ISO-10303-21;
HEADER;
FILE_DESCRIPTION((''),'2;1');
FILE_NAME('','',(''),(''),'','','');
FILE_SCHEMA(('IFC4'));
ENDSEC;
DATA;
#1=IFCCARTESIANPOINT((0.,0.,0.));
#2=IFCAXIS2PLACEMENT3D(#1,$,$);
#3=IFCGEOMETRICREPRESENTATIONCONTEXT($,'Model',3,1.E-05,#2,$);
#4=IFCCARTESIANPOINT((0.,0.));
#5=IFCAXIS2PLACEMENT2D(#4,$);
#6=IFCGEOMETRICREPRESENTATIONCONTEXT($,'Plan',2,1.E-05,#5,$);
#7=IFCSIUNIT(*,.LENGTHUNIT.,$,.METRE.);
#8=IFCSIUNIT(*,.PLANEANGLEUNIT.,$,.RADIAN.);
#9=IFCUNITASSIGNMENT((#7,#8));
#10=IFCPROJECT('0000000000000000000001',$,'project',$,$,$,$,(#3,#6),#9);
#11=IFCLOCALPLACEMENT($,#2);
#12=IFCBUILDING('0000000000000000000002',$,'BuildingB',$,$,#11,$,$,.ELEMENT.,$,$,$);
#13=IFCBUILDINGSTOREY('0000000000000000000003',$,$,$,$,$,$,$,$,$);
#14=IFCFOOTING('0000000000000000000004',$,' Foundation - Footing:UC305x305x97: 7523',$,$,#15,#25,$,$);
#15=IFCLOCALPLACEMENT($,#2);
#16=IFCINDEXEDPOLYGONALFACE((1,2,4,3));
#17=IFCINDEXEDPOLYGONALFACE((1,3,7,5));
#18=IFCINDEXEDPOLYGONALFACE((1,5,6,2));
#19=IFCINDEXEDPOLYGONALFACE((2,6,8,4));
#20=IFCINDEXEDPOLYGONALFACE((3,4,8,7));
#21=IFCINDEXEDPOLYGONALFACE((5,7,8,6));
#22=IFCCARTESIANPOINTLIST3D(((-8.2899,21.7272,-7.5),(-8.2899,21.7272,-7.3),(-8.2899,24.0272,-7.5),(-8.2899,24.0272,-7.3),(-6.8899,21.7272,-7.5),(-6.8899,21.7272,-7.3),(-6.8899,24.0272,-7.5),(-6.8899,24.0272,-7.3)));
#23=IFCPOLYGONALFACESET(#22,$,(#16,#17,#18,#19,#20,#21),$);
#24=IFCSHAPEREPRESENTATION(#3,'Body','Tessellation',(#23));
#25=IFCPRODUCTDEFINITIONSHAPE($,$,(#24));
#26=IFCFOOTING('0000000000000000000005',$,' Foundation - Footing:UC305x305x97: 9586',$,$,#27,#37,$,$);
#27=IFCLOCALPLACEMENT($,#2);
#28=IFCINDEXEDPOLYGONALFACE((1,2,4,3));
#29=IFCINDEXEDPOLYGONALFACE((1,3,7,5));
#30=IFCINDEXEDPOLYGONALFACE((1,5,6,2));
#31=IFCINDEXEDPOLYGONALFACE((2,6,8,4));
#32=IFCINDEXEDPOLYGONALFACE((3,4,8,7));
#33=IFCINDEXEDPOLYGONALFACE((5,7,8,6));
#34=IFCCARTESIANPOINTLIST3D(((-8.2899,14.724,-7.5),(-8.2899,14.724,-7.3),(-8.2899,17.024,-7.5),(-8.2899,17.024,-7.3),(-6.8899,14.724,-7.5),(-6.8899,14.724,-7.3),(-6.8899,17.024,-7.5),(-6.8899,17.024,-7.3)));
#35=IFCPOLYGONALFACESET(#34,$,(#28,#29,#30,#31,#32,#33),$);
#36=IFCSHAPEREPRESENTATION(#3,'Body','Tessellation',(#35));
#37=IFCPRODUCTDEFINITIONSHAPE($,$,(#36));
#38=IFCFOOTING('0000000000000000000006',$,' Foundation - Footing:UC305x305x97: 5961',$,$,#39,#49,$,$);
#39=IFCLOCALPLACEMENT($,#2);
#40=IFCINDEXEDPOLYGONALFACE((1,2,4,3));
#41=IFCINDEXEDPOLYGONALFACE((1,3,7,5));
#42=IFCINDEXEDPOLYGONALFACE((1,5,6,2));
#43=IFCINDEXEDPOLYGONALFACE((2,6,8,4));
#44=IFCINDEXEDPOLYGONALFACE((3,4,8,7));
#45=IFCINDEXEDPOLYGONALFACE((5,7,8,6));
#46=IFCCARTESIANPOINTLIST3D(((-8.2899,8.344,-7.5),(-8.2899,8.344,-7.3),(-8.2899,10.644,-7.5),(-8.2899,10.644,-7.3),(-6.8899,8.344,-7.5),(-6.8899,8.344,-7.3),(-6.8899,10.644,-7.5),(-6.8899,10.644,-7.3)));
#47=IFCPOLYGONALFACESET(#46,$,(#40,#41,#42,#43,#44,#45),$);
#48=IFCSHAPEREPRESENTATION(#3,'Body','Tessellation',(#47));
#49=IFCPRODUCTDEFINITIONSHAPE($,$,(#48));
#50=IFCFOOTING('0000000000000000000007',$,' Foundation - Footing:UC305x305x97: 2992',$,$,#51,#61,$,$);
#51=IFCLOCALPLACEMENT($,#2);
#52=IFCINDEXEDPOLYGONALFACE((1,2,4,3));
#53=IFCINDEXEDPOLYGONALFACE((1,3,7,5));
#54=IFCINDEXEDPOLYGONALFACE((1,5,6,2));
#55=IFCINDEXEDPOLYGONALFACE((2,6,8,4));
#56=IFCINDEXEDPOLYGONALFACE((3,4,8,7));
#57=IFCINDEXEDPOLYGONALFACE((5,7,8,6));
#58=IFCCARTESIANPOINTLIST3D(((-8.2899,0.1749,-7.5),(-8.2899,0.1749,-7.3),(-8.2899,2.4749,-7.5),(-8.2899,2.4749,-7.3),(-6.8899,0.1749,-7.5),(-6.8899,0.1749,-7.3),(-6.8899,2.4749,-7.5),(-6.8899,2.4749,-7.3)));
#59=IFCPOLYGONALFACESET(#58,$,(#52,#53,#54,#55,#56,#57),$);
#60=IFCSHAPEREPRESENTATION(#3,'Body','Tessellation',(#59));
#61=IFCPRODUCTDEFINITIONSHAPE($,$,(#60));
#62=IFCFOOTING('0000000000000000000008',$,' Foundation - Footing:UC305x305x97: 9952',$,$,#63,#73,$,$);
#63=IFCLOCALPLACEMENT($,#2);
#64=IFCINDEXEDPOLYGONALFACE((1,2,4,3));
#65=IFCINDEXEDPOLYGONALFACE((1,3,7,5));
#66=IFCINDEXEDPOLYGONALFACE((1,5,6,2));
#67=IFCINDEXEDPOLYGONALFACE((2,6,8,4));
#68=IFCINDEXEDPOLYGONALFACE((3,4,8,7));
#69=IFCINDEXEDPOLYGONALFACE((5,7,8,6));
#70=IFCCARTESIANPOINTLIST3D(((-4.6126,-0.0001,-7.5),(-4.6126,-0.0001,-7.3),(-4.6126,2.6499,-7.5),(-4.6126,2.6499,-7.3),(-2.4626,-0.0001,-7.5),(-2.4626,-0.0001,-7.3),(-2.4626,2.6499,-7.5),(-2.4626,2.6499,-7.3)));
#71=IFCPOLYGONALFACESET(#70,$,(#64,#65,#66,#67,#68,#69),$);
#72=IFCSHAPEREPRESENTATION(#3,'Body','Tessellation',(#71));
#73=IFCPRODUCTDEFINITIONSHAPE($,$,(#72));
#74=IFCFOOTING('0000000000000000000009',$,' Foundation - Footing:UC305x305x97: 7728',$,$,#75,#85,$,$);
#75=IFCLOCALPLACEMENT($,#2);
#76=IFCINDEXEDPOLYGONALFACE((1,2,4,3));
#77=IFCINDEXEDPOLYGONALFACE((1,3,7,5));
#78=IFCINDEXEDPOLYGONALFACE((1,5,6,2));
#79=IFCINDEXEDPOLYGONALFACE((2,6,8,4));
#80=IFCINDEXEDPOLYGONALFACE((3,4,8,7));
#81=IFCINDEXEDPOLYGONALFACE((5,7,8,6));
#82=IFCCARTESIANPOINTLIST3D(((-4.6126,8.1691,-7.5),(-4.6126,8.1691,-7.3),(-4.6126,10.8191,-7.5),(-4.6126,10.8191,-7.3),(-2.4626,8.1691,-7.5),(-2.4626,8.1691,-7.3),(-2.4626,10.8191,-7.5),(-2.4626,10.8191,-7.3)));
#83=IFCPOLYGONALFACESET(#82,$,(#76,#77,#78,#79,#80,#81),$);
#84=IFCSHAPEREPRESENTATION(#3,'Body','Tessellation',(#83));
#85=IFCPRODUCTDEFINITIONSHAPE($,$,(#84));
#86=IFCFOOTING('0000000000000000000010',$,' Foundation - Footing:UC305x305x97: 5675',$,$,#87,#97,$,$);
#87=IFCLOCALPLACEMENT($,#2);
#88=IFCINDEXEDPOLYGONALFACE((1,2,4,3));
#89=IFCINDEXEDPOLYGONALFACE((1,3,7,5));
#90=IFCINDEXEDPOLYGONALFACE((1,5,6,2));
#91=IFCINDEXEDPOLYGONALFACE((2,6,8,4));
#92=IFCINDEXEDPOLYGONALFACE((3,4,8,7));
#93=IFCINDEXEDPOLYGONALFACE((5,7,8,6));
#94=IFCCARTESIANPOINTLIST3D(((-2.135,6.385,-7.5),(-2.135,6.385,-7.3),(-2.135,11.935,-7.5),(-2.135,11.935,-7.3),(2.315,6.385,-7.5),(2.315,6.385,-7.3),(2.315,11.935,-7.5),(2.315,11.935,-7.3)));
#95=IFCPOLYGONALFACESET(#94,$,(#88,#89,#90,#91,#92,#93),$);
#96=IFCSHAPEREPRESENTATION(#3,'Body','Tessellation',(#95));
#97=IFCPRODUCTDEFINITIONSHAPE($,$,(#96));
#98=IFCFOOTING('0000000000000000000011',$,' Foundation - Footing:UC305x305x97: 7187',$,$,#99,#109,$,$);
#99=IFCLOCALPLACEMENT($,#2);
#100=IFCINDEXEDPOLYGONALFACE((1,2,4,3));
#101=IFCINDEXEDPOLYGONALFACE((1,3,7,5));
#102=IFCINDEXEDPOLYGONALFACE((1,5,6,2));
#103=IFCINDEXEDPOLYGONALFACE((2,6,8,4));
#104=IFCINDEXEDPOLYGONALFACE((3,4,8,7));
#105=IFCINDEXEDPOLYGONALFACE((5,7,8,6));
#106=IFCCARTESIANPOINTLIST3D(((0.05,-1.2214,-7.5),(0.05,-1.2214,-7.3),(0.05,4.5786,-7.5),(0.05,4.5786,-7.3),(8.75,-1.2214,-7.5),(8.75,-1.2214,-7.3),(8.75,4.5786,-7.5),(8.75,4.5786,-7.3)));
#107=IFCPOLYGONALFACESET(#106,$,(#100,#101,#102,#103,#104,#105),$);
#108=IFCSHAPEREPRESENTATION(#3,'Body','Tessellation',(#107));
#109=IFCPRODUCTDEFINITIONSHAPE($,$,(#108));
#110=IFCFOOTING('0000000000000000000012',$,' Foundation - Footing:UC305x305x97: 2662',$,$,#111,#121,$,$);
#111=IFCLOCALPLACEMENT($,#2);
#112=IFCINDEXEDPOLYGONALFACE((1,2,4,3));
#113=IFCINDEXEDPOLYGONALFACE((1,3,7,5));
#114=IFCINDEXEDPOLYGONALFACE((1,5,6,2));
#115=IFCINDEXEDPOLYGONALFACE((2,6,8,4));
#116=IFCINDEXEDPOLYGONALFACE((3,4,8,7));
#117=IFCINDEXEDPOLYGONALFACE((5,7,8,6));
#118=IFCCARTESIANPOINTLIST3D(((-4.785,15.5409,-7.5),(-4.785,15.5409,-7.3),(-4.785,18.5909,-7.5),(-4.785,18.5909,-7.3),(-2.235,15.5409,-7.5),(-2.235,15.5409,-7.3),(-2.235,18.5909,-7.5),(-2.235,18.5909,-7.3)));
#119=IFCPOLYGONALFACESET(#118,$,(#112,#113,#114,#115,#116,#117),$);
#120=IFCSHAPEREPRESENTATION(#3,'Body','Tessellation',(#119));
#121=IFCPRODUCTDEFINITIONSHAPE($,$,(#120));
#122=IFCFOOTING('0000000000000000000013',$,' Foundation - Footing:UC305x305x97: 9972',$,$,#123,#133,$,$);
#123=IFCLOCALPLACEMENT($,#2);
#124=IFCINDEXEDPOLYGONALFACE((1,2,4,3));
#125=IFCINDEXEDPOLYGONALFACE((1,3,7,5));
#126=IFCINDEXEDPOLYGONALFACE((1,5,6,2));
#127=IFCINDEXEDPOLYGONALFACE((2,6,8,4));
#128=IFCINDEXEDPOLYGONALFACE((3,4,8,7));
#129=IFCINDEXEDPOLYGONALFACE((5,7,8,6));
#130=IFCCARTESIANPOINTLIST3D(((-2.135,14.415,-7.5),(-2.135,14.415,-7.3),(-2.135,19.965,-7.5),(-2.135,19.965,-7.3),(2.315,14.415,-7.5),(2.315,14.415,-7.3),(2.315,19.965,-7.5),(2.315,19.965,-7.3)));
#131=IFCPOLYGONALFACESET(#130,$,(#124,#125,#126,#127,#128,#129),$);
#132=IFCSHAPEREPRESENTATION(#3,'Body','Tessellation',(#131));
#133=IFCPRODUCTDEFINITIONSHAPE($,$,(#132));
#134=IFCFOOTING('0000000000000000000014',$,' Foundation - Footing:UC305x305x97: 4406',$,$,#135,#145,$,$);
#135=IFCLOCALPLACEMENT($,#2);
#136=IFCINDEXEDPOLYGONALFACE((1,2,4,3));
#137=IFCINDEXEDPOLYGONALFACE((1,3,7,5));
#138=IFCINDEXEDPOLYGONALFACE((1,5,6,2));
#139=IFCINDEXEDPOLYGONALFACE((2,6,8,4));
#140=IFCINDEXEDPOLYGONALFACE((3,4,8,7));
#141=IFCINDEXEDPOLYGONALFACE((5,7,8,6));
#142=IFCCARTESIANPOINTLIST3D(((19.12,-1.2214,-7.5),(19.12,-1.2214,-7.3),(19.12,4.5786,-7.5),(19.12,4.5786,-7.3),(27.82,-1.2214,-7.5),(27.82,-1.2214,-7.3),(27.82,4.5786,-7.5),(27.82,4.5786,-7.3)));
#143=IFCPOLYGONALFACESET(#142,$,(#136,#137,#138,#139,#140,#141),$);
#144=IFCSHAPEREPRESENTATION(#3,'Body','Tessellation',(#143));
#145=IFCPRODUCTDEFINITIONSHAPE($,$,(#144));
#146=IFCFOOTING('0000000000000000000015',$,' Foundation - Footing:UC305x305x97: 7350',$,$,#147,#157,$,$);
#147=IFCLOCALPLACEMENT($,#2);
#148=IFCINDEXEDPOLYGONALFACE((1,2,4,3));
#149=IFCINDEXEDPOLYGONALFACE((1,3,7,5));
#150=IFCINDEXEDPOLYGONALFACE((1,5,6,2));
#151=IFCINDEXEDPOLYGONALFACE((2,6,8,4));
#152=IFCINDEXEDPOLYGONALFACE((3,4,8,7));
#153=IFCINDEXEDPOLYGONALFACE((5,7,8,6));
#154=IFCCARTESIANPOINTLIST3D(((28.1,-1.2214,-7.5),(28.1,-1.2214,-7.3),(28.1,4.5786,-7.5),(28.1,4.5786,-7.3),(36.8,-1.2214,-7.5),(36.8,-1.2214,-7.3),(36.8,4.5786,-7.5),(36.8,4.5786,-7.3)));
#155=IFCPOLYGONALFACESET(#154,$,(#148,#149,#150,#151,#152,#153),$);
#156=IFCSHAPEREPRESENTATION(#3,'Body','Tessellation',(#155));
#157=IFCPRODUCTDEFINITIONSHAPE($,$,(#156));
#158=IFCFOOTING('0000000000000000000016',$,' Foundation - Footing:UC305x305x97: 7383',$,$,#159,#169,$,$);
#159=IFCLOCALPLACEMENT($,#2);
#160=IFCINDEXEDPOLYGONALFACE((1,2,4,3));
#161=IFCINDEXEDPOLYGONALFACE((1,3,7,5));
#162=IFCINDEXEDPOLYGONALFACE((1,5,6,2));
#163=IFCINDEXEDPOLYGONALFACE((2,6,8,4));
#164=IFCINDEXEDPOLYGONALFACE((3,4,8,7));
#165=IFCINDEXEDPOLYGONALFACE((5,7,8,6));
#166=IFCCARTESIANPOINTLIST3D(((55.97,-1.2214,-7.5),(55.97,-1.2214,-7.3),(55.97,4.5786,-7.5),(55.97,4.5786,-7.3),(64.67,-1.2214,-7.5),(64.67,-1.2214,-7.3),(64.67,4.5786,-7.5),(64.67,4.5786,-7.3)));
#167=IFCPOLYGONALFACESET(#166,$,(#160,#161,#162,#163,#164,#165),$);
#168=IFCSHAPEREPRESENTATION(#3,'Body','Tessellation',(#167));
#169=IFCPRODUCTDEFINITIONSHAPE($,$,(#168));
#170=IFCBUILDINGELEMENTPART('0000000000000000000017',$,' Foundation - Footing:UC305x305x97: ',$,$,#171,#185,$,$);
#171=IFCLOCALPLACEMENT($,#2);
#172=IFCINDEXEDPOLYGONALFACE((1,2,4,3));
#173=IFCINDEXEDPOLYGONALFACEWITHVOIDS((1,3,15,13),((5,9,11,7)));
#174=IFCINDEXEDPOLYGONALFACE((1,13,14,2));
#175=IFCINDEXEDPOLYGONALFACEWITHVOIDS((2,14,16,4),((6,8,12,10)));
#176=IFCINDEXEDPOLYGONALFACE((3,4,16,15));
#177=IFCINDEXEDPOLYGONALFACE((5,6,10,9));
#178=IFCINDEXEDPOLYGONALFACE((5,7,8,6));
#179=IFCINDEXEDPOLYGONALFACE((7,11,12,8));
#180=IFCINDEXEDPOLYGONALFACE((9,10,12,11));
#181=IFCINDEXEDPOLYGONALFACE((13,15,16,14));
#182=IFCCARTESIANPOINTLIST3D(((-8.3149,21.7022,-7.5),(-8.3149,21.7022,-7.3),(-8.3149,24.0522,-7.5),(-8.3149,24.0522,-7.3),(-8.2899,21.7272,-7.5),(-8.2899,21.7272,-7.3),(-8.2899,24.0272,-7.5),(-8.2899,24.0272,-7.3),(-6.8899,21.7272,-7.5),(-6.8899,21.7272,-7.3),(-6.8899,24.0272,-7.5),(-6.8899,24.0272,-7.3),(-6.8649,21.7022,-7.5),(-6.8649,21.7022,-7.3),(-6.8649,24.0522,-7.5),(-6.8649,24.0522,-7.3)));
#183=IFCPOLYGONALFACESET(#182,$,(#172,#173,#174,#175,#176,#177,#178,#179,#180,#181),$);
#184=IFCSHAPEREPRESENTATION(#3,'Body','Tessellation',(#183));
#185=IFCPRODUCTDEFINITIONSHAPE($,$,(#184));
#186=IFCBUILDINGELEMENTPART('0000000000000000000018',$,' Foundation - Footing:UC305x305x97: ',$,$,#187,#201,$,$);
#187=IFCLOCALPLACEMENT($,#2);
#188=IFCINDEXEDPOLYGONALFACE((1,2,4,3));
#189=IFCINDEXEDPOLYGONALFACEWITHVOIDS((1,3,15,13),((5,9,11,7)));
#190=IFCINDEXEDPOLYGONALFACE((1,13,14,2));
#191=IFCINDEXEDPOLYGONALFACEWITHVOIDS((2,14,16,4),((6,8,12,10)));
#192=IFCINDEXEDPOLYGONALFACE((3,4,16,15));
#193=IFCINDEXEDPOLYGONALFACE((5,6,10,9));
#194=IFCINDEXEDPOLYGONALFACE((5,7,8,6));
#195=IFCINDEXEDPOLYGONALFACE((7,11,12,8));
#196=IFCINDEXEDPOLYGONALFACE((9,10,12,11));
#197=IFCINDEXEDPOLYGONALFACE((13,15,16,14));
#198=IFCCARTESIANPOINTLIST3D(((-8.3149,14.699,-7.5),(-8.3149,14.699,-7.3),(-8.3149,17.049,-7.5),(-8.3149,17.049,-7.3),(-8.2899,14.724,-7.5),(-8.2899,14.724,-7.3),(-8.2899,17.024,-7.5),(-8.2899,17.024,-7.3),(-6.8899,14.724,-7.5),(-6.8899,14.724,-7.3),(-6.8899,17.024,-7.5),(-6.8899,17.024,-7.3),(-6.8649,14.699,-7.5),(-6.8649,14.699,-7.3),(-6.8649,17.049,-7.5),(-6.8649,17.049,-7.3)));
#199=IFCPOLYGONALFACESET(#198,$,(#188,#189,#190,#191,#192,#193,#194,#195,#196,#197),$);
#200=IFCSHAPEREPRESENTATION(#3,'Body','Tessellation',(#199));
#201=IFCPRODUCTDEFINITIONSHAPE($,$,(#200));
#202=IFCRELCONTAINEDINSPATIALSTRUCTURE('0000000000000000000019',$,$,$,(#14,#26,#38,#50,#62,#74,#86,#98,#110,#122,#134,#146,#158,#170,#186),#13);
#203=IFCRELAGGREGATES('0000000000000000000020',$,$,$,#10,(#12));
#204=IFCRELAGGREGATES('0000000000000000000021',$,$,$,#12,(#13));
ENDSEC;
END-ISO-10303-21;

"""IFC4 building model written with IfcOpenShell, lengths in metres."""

from ifc_helpers import new_model, si_unit, origin, origin_2d, place, context, project, spatial, polyline, outline, extrude, element, save


model = new_model("IFC4")

# Units and contexts
model_context = context("Model", 3, precision=1e-05, world=origin())
plan_context = context("Plan", 2, precision=1e-05, world=origin_2d())
ifc_project = project(units=[si_unit("LENGTHUNIT", "METRE"), si_unit("PLANEANGLEUNIT", "RADIAN")], contexts=[model_context, plan_context])

# Building, storey
building_placement = place(None, origin())
building = spatial("IfcBuilding", under=ifc_project, at=building_placement, Name="BuildingB", CompositionType="ELEMENT")
storey = spatial("IfcBuildingStorey", under=building)

# Footings
element("IfcFooting", 1, inside=storey, Name=" Foundation - Footing:UC305x305x97: 7523", context=model_context, shape_type="SweptSolid", body=[
    extrude(outline(polyline([(-6.8899, 24.0272, -7.5), (-8.2899, 24.0272, -7.5), (-8.2899, 21.7272, -7.5), (-6.8899, 21.7272, -7.5), (-6.8899, 24.0272, -7.5)])), None, (0.0, 0.0, 1.0), 0.2),
])
element("IfcFooting", 2, inside=storey, Name=" Foundation - Footing:UC305x305x97: 9586", context=model_context, shape_type="SweptSolid", body=[
    extrude(outline(polyline([(-8.2899, 14.724, -7.5), (-6.8899, 14.724, -7.5), (-6.8899, 17.024, -7.5), (-8.2899, 17.024, -7.5), (-8.2899, 14.724, -7.5)])), None, (0.0, 0.0, 1.0), 0.2),
])
element("IfcFooting", 3, inside=storey, Name=" Foundation - Footing:UC305x305x97: 5961", context=model_context, shape_type="SweptSolid", body=[
    extrude(outline(polyline([(-8.2899, 8.344, -7.5), (-6.8899, 8.344, -7.5), (-6.8899, 10.644, -7.5), (-8.2899, 10.644, -7.5), (-8.2899, 8.344, -7.5)])), None, (0.0, 0.0, 1.0), 0.2),
])
element("IfcFooting", 4, inside=storey, Name=" Foundation - Footing:UC305x305x97: 2992", context=model_context, shape_type="SweptSolid", body=[
    extrude(outline(polyline([(-8.2899, 0.1749, -7.5), (-6.8899, 0.1749, -7.5), (-6.8899, 2.4749, -7.5), (-8.2899, 2.4749, -7.5), (-8.2899, 0.1749, -7.5)])), None, (0.0, 0.0, 1.0), 0.2),
])
element("IfcFooting", 5, inside=storey, Name=" Foundation - Footing:UC305x305x97: 9952", context=model_context, shape_type="SweptSolid", body=[
    extrude(outline(polyline([(-4.6126, -0.0001, -7.5), (-2.4626, -0.0001, -7.5), (-2.4626, 2.6499, -7.5), (-4.6126, 2.6499, -7.5), (-4.6126, -0.0001, -7.5)])), None, (0.0, 0.0, 1.0), 0.2),
])
element("IfcFooting", 6, inside=storey, Name=" Foundation - Footing:UC305x305x97: 7728", context=model_context, shape_type="SweptSolid", body=[
    extrude(outline(polyline([(-4.6126, 8.1691, -7.5), (-2.4626, 8.1691, -7.5), (-2.4626, 10.8191, -7.5), (-4.6126, 10.8191, -7.5), (-4.6126, 8.1691, -7.5)])), None, (0.0, 0.0, 1.0), 0.2),
])
element("IfcFooting", 7, inside=storey, Name=" Foundation - Footing:UC305x305x97: 5675", context=model_context, shape_type="SweptSolid", body=[
    extrude(outline(polyline([(-2.135, 6.385, -7.5), (2.315, 6.385, -7.5), (2.315, 11.935, -7.5), (-2.135, 11.935, -7.5), (-2.135, 6.385, -7.5)])), None, (0.0, 0.0, 1.0), 0.2),
])
element("IfcFooting", 8, inside=storey, Name=" Foundation - Footing:UC305x305x97: 7187", context=model_context, shape_type="SweptSolid", body=[
    extrude(outline(polyline([(0.05, -1.2214, -7.5), (8.75, -1.2214, -7.5), (8.75, 4.5786, -7.5), (0.05, 4.5786, -7.5), (0.05, -1.2214, -7.5)])), None, (0.0, 0.0, 1.0), 0.2),
])
element("IfcFooting", 9, inside=storey, Name=" Foundation - Footing:UC305x305x97: 2662", context=model_context, shape_type="SweptSolid", body=[
    extrude(outline(polyline([(-4.785, 15.5409, -7.5), (-2.235, 15.5409, -7.5), (-2.235, 18.5909, -7.5), (-4.785, 18.5909, -7.5), (-4.785, 15.5409, -7.5)])), None, (0.0, 0.0, 1.0), 0.2),
])
element("IfcFooting", 10, inside=storey, Name=" Foundation - Footing:UC305x305x97: 9972", context=model_context, shape_type="SweptSolid", body=[
    extrude(outline(polyline([(-2.135, 14.415, -7.5), (2.315, 14.415, -7.5), (2.315, 19.965, -7.5), (-2.135, 19.965, -7.5), (-2.135, 14.415, -7.5)])), None, (0.0, 0.0, 1.0), 0.2),
])
element("IfcFooting", 11, inside=storey, Name=" Foundation - Footing:UC305x305x97: 4406", context=model_context, shape_type="SweptSolid", body=[
    extrude(outline(polyline([(19.12, -1.2214, -7.5), (27.82, -1.2214, -7.5), (27.82, 4.5786, -7.5), (19.12, 4.5786, -7.5), (19.12, -1.2214, -7.5)])), None, (0.0, 0.0, 1.0), 0.2),
])
element("IfcFooting", 12, inside=storey, Name=" Foundation - Footing:UC305x305x97: 7350", context=model_context, shape_type="SweptSolid", body=[
    extrude(outline(polyline([(28.1, -1.2214, -7.5), (36.8, -1.2214, -7.5), (36.8, 4.5786, -7.5), (28.1, 4.5786, -7.5), (28.1, -1.2214, -7.5)])), None, (0.0, 0.0, 1.0), 0.2),
])
element("IfcFooting", 13, inside=storey, Name=" Foundation - Footing:UC305x305x97: 7383", context=model_context, shape_type="SweptSolid", body=[
    extrude(outline(polyline([(55.97, -1.2214, -7.5), (64.67, -1.2214, -7.5), (64.67, 4.5786, -7.5), (55.97, 4.5786, -7.5), (55.97, -1.2214, -7.5)])), None, (0.0, 0.0, 1.0), 0.2),
])

# Building element parts, openings
building_element_part_1 = element("IfcBuildingElementPart", 14, inside=storey, Name=" Foundation - Footing:UC305x305x97: ", context=model_context, shape_type="SweptSolid", body=[
    extrude(outline(polyline([(-6.8649, 24.0522, -7.5), (-8.3149, 24.0522, -7.5), (-8.3149, 21.7022, -7.5), (-6.8649, 21.7022, -7.5), (-6.8649, 24.0522, -7.5)])), None, (0.0, 0.0, 1.0), 0.2),
])
element("IfcOpeningElement", 15, inside=storey, cuts=building_element_part_1, context=model_context, shape_type="SweptSolid", body=[
    extrude(outline(polyline([(-6.8899, 24.0272, -7.5), (-8.2899, 24.0272, -7.5), (-8.2899, 21.7272, -7.5), (-6.8899, 21.7272, -7.5), (-6.8899, 24.0272, -7.5)])), None, (0.0, 0.0, 1.0), 0.2),
])
building_element_part_2 = element("IfcBuildingElementPart", 16, inside=storey, Name=" Foundation - Footing:UC305x305x97: ", context=model_context, shape_type="SweptSolid", body=[
    extrude(outline(polyline([(-8.3149, 14.699, -7.5), (-6.8649, 14.699, -7.5), (-6.8649, 17.049, -7.5), (-8.3149, 17.049, -7.5), (-8.3149, 14.699, -7.5)])), None, (0.0, 0.0, 1.0), 0.2),
])
element("IfcOpeningElement", 17, inside=storey, cuts=building_element_part_2, context=model_context, shape_type="SweptSolid", body=[
    extrude(outline(polyline([(-8.2899, 14.724, -7.5), (-6.8899, 14.724, -7.5), (-6.8899, 17.024, -7.5), (-8.2899, 17.024, -7.5), (-8.2899, 14.724, -7.5)])), None, (0.0, 0.0, 1.0), 0.2),
])

save(model, "model.ifc")
